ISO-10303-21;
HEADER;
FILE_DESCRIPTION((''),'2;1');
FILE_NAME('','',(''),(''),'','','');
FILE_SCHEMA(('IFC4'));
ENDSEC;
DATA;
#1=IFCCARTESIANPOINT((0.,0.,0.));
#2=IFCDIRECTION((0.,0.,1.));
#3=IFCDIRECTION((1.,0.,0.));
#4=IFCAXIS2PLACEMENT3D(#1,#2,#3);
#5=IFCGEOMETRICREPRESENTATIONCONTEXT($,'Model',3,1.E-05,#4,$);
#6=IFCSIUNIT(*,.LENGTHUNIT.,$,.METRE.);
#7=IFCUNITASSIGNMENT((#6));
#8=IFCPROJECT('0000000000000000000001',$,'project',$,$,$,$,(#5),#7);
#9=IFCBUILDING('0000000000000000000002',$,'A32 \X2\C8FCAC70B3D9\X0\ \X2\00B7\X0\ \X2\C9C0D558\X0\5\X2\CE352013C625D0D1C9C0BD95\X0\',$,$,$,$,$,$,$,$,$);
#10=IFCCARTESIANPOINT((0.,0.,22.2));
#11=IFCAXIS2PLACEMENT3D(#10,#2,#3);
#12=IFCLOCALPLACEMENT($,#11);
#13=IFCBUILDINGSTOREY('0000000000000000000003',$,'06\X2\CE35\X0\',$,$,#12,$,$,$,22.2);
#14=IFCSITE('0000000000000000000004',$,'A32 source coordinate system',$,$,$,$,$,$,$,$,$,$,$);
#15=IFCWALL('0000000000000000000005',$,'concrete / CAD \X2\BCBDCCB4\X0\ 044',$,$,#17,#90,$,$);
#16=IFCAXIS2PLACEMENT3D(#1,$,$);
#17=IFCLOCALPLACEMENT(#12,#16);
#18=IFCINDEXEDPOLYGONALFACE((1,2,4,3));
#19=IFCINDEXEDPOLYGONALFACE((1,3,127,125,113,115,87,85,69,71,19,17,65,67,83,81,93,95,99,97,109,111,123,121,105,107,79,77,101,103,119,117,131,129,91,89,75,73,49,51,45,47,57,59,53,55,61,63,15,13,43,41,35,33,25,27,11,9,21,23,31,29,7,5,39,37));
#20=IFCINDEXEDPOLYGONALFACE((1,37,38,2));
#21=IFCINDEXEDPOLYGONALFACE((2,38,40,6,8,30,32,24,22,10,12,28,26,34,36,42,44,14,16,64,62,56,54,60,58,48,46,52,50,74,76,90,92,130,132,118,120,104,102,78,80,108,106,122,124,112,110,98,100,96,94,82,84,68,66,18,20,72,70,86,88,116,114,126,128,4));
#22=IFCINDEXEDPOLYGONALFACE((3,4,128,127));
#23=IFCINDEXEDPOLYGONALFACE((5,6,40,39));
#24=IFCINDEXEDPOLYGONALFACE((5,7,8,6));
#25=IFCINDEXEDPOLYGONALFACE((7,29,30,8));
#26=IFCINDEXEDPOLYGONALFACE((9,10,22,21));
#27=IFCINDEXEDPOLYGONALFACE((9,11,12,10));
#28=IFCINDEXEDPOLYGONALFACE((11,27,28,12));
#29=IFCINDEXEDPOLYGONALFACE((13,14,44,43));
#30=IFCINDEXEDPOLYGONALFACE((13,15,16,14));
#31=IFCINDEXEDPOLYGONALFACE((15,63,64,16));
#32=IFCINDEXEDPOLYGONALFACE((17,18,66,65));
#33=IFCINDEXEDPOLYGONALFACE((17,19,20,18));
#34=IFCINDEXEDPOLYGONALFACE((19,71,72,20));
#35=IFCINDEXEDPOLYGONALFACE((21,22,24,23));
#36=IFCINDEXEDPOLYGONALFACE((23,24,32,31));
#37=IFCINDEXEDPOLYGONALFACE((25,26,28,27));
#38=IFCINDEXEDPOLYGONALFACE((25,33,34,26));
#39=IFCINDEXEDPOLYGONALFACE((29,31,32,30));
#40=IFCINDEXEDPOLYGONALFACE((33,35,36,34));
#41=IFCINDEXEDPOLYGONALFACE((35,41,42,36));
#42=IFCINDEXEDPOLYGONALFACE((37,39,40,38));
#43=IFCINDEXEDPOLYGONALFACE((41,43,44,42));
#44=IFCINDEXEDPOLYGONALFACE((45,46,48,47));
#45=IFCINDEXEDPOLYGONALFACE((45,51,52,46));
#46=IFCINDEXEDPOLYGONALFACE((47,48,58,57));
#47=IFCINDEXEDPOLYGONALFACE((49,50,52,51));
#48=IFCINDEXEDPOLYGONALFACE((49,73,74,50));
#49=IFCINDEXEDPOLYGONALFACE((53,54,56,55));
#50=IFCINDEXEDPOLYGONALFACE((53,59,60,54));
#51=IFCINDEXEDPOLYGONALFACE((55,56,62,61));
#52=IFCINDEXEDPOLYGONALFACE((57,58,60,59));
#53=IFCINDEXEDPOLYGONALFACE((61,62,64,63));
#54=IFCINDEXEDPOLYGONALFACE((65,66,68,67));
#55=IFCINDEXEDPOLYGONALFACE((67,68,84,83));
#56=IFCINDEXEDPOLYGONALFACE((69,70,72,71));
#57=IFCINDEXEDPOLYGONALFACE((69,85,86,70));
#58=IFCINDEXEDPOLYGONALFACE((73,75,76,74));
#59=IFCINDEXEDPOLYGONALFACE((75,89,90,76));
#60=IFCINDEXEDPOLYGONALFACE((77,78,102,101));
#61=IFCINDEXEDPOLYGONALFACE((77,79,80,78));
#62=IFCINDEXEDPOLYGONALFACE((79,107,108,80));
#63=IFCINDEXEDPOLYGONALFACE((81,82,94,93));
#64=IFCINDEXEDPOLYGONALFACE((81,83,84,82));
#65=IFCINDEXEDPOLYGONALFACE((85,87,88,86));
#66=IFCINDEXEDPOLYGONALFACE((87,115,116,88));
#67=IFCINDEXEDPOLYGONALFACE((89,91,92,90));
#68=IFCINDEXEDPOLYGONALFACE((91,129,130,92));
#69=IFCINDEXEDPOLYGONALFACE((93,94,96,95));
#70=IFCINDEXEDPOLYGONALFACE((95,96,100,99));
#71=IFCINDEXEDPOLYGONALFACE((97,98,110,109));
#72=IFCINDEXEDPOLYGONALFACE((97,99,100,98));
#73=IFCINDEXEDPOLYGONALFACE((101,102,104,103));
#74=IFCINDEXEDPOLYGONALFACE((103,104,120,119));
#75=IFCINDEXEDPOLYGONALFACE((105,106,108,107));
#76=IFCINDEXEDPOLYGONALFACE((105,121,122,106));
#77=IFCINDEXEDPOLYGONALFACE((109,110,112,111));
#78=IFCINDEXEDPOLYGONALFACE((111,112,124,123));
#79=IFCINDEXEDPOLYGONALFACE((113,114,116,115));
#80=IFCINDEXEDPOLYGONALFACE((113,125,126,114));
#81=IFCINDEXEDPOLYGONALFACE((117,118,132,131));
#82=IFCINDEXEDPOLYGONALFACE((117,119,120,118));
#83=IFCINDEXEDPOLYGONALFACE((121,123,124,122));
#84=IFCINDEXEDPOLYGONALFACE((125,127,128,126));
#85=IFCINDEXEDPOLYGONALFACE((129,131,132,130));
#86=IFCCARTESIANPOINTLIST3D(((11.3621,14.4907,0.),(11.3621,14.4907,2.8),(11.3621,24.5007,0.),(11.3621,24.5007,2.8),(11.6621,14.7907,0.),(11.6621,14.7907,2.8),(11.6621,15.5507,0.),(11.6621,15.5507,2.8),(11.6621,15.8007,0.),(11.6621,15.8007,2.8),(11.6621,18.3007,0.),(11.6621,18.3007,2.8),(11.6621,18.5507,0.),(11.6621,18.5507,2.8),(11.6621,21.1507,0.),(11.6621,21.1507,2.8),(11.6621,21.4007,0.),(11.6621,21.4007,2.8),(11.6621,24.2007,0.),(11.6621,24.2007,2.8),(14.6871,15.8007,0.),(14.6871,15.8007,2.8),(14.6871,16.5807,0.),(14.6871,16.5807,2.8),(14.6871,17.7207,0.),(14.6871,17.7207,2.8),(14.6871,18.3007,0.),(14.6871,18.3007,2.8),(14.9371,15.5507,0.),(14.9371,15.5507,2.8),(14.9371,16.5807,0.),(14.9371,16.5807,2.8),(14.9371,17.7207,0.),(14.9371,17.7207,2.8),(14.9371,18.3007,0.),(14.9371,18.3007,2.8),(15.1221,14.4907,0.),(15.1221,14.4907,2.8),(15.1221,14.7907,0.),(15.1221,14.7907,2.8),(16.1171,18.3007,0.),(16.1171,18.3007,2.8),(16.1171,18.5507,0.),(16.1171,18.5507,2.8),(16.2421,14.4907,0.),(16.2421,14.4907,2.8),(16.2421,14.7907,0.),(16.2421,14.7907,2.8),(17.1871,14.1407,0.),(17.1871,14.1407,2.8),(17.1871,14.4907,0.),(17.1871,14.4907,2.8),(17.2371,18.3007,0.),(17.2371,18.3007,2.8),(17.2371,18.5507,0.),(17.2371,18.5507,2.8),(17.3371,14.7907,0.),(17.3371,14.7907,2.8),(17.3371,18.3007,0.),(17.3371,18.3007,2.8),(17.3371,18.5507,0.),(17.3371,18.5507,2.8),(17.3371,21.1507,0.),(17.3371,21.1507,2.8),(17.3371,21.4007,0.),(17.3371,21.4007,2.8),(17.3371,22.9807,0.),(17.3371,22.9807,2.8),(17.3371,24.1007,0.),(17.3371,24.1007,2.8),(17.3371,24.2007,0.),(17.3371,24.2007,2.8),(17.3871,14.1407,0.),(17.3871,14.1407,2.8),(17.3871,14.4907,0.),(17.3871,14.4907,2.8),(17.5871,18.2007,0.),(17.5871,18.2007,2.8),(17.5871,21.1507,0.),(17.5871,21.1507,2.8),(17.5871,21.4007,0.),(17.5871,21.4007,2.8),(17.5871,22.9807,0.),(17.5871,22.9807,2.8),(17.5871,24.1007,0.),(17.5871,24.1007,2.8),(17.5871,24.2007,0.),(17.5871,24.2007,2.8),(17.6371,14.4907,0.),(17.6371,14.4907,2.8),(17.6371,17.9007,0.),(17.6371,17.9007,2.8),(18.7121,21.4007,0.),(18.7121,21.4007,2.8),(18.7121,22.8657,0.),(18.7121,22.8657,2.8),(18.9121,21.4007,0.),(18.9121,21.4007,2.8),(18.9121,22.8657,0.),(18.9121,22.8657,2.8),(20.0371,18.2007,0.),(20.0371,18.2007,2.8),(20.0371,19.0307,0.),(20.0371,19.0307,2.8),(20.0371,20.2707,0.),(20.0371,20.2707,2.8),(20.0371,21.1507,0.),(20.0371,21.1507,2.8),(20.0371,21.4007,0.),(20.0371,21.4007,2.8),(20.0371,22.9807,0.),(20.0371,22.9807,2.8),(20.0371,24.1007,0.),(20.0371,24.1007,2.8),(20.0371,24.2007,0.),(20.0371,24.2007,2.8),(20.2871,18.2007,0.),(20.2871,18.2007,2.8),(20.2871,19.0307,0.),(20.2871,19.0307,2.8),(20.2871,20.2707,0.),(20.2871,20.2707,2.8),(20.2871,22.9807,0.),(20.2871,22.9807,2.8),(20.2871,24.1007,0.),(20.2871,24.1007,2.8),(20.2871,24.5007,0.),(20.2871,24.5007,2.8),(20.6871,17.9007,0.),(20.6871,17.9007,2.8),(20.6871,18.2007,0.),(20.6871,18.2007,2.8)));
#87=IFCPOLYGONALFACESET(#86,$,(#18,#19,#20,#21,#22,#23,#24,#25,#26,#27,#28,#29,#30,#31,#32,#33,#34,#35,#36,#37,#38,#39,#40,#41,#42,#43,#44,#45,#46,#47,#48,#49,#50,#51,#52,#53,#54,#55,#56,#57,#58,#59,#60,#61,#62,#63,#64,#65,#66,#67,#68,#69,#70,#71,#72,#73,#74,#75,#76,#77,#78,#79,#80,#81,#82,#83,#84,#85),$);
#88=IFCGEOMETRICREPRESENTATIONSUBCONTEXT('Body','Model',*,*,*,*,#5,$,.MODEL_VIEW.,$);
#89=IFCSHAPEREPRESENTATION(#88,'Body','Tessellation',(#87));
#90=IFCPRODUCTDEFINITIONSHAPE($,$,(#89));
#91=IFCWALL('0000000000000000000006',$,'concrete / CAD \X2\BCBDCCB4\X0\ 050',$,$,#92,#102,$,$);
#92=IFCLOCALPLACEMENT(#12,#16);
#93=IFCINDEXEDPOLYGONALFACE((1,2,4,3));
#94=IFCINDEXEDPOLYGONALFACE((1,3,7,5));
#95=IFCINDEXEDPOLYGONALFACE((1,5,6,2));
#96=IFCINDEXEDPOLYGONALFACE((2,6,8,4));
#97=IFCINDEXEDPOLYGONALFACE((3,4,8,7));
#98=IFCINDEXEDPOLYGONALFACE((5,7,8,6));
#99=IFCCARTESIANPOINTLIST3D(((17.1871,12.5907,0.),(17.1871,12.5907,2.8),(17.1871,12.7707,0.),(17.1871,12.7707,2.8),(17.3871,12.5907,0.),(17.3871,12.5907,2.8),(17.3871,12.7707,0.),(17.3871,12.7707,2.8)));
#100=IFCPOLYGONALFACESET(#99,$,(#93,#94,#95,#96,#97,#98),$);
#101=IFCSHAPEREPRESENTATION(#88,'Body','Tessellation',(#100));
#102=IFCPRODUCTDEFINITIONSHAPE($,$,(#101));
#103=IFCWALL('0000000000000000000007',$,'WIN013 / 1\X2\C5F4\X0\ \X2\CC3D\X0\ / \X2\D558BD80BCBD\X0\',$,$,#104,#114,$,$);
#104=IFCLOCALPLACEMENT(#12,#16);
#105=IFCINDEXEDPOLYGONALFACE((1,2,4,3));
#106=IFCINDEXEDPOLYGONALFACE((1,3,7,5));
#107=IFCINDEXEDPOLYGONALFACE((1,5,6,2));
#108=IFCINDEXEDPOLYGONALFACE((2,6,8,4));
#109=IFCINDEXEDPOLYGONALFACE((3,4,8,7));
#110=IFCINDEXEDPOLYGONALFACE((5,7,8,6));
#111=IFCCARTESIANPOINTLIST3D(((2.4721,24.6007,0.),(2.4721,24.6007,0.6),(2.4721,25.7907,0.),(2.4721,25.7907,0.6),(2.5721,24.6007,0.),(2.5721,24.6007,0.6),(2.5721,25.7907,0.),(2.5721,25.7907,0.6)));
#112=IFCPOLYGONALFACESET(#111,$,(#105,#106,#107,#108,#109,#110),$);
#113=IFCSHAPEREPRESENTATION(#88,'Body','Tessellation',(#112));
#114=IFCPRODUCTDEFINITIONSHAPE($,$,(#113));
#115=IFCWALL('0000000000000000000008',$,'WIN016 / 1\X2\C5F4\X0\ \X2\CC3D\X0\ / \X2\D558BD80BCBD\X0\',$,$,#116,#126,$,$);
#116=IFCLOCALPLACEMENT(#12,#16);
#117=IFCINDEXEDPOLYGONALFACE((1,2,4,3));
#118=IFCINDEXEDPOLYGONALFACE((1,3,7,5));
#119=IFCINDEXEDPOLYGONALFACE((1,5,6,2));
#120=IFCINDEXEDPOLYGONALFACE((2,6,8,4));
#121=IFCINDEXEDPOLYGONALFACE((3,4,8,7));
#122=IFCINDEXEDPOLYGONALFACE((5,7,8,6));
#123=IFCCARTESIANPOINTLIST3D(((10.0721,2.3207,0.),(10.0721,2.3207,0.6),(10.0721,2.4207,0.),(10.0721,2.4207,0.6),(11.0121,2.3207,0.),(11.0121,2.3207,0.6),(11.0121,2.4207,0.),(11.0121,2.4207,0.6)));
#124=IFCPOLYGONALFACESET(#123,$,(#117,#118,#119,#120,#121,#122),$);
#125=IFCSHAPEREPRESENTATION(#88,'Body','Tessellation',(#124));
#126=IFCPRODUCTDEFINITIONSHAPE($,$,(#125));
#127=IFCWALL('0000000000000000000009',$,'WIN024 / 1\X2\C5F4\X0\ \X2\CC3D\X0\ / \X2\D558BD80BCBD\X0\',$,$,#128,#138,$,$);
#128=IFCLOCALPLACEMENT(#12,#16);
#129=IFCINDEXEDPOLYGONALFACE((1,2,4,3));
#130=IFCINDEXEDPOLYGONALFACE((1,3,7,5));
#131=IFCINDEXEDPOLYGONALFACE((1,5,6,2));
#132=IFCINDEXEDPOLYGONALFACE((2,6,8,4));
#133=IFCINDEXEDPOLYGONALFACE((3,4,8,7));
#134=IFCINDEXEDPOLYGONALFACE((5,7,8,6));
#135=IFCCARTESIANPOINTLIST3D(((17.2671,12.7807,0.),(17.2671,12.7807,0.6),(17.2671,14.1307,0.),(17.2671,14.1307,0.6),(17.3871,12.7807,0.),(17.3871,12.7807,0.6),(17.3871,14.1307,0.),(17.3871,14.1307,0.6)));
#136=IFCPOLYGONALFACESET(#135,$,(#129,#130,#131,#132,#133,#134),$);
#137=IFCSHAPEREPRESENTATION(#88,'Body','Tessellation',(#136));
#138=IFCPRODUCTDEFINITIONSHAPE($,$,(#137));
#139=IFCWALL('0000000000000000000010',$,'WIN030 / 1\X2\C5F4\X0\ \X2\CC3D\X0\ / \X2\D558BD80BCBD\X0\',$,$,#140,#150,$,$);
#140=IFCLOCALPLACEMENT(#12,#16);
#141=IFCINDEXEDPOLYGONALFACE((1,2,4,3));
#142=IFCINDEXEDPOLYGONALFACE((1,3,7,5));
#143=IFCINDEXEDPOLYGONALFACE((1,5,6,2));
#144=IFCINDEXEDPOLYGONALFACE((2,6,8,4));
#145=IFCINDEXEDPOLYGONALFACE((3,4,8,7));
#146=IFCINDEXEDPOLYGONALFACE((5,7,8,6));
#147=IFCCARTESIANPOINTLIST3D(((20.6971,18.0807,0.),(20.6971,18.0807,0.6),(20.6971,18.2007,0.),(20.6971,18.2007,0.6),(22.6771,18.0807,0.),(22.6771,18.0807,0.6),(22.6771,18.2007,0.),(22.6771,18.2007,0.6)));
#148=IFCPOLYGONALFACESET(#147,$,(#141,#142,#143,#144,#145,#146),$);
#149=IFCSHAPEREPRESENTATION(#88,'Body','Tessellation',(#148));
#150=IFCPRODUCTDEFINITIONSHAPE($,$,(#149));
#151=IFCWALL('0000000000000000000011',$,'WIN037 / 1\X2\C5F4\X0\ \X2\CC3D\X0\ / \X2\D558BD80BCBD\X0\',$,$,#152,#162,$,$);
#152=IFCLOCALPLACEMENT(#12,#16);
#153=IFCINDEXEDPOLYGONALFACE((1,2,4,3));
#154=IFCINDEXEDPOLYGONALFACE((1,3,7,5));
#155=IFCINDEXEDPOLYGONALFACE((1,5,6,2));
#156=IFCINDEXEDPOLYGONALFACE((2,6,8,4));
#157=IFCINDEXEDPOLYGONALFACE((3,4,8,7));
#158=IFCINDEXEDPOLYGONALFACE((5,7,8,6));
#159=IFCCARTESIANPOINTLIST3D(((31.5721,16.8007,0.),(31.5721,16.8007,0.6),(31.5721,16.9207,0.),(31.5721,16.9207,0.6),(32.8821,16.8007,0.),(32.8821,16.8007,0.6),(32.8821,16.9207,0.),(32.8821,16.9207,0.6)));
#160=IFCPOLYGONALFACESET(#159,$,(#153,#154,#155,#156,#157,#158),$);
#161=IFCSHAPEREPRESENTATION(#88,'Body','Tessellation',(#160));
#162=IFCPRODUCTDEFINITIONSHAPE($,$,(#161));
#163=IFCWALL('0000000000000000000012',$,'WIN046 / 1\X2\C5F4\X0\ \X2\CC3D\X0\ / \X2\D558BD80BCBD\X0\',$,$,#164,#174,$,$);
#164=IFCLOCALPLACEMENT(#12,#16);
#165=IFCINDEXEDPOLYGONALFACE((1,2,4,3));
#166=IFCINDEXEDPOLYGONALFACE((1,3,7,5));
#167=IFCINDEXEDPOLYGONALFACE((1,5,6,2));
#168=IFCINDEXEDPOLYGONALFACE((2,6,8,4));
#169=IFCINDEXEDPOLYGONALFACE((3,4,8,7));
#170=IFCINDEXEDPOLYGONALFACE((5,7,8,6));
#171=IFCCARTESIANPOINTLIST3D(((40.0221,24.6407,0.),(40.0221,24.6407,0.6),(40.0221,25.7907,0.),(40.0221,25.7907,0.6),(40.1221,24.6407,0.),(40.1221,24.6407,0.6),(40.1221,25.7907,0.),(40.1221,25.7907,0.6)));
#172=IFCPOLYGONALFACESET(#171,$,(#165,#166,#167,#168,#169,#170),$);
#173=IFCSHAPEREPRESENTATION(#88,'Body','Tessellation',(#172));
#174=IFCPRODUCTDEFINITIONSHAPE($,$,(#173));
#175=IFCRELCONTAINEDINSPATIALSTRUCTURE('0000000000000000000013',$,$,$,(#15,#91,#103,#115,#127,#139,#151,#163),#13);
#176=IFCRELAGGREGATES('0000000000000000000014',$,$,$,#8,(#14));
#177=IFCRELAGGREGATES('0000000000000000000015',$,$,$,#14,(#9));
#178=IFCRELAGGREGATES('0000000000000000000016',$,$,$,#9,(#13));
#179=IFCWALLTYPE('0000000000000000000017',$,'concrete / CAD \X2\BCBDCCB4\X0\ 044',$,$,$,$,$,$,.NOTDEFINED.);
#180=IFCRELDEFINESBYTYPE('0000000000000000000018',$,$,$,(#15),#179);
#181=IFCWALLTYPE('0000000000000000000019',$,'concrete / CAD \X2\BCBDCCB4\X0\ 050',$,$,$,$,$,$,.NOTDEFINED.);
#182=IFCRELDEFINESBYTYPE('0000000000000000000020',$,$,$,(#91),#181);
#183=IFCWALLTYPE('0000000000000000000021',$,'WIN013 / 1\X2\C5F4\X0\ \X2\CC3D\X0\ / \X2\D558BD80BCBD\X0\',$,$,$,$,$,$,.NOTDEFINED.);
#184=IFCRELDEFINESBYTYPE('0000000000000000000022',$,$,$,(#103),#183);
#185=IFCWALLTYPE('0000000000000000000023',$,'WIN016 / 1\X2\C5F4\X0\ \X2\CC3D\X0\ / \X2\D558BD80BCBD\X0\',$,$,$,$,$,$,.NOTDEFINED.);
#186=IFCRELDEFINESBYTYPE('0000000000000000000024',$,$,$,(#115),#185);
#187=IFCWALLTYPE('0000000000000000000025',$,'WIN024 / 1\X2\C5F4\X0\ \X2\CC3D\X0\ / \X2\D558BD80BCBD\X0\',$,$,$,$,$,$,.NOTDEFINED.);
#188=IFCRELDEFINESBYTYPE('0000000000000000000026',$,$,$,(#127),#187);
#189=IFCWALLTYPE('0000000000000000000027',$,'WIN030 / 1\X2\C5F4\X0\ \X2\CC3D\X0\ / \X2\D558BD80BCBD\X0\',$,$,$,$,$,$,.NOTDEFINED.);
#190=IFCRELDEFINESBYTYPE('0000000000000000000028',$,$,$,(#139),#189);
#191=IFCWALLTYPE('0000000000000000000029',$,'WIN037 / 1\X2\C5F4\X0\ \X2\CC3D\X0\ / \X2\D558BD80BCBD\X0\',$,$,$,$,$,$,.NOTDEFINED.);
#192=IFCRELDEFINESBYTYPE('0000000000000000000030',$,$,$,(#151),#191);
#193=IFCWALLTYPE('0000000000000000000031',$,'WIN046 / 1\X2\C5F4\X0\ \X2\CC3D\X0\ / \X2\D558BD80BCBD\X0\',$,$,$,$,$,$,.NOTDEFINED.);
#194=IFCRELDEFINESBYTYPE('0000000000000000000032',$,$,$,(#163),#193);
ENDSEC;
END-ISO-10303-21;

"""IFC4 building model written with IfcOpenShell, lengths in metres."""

from ifc_helpers import new_model, si_unit, frame, origin, origin_with_axes, place, context, subcontext, project, spatial, polyline, outline, extrude, source, transform, mapped, type_object, type_shapes, element, save


model = new_model("IFC4")

# Units and contexts
model_context = context("Model", 3, precision=1e-05, world=origin_with_axes())
body_context = subcontext(model_context, "Body", "Model", "MODEL_VIEW")
ifc_project = project(units=[si_unit("LENGTHUNIT", "METRE")], contexts=[model_context])

# Site, building, storey
site = spatial("IfcSite", under=ifc_project, Name="A32 source coordinate system")
building = spatial("IfcBuilding", under=site, Name="A32 주거동 · 지하5층–옥탑지붕")
storey_placement = place(None, frame((0.0, 0.0, 22.2), z_axis=(0.0, 0.0, 1.0), x_axis=(1.0, 0.0, 0.0)))
storey = spatial("IfcBuildingStorey", under=building, at=storey_placement, Name="06층", Elevation=22.2)

# Walls
wall_type_1 = type_object("IfcWallType", Name="concrete / CAD 벽체 044", PredefinedType="NOTDEFINED")
shared_shape_1 = source(origin(), body_context, "Body", "SweptSolid", [
    extrude(outline(polyline([(17.3371, 21.4007), (17.3371, 22.9807), (17.5871, 22.9807), (17.5871, 21.4007), (18.7121, 21.4007), (18.7121, 22.8657), (18.9121, 22.8657), (18.9121, 21.4007), (20.0371, 21.4007), (20.0371, 22.9807), (20.2871, 22.9807), (20.2871, 20.2707), (20.0371, 20.2707), (20.0371, 21.1507), (17.5871, 21.1507), (17.5871, 18.2007), (20.0371, 18.2007), (20.0371, 19.0307), (20.2871, 19.0307), (20.2871, 18.2007), (20.6871, 18.2007), (20.6871, 17.9007), (17.6371, 17.9007), (17.6371, 14.4907), (17.3871, 14.4907), (17.3871, 14.1407), (17.1871, 14.1407), (17.1871, 14.4907), (16.2421, 14.4907), (16.2421, 14.7907), (17.3371, 14.7907), (17.3371, 18.3007), (17.2371, 18.3007), (17.2371, 18.5507), (17.3371, 18.5507), (17.3371, 21.1507), (11.6621, 21.1507), (11.6621, 18.5507), (16.1171, 18.5507), (16.1171, 18.3007), (14.9371, 18.3007), (14.9371, 17.7207), (14.6871, 17.7207), (14.6871, 18.3007), (11.6621, 18.3007), (11.6621, 15.8007), (14.6871, 15.8007), (14.6871, 16.5807), (14.9371, 16.5807), (14.9371, 15.5507), (11.6621, 15.5507), (11.6621, 14.7907), (15.1221, 14.7907), (15.1221, 14.4907), (11.3621, 14.4907), (11.3621, 24.5007), (20.2871, 24.5007), (20.2871, 24.1007), (20.0371, 24.1007), (20.0371, 24.2007), (17.5871, 24.2007), (17.5871, 24.1007), (17.3371, 24.1007), (17.3371, 24.2007), (11.6621, 24.2007), (11.6621, 21.4007), (17.3371, 21.4007)])), origin(), (0.0, 0.0, 1.0), 2.8),
])
type_shapes(wall_type_1, [shared_shape_1])
wall_1_placement = place(storey_placement, origin_with_axes())
element("IfcWall", 1, at=wall_1_placement, inside=storey, type_object=wall_type_1, Name="concrete / CAD 벽체 044", context=body_context, shape_type="MappedRepresentation", body=[
    mapped(shared_shape_1, transform((0.0, 0.0, 0.0), scale=1.0)),
])
wall_type_2 = type_object("IfcWallType", Name="concrete / CAD 벽체 050", PredefinedType="NOTDEFINED")
shared_shape_2 = source(origin(), body_context, "Body", "SweptSolid", [
    extrude(outline(polyline([(17.3871, 12.5907), (17.1871, 12.5907), (17.1871, 12.7707), (17.3871, 12.7707), (17.3871, 12.5907)])), origin(), (0.0, 0.0, 1.0), 2.8),
])
type_shapes(wall_type_2, [shared_shape_2])
wall_2_placement = place(storey_placement, origin_with_axes())
element("IfcWall", 2, at=wall_2_placement, inside=storey, type_object=wall_type_2, Name="concrete / CAD 벽체 050", context=body_context, shape_type="MappedRepresentation", body=[
    mapped(shared_shape_2, transform((0.0, 0.0, 0.0), scale=1.0)),
])
wall_type_3 = type_object("IfcWallType", Name="WIN013 / 1열 창 / 하부벽", PredefinedType="NOTDEFINED")
shared_shape_3 = source(origin(), body_context, "Body", "SweptSolid", [
    extrude(outline(polyline([(2.5721, 25.7907), (2.5721, 24.6007), (2.4721, 24.6007), (2.4721, 25.7907), (2.5721, 25.7907)])), origin(), (0.0, 0.0, 1.0), 0.6),
])
type_shapes(wall_type_3, [shared_shape_3])
wall_3_placement = place(storey_placement, origin_with_axes())
element("IfcWall", 3, at=wall_3_placement, inside=storey, type_object=wall_type_3, Name="WIN013 / 1열 창 / 하부벽", context=body_context, shape_type="MappedRepresentation", body=[
    mapped(shared_shape_3, transform((0.0, 0.0, 0.0), scale=1.0)),
])
wall_type_4 = type_object("IfcWallType", Name="WIN016 / 1열 창 / 하부벽", PredefinedType="NOTDEFINED")
shared_shape_4 = source(origin(), body_context, "Body", "SweptSolid", [
    extrude(outline(polyline([(11.0121, 2.4207), (11.0121, 2.3207), (10.0721, 2.3207), (10.0721, 2.4207), (11.0121, 2.4207)])), origin(), (0.0, 0.0, 1.0), 0.6),
])
type_shapes(wall_type_4, [shared_shape_4])
wall_4_placement = place(storey_placement, origin_with_axes())
element("IfcWall", 4, at=wall_4_placement, inside=storey, type_object=wall_type_4, Name="WIN016 / 1열 창 / 하부벽", context=body_context, shape_type="MappedRepresentation", body=[
    mapped(shared_shape_4, transform((0.0, 0.0, 0.0), scale=1.0)),
])
wall_type_5 = type_object("IfcWallType", Name="WIN024 / 1열 창 / 하부벽", PredefinedType="NOTDEFINED")
shared_shape_5 = source(origin(), body_context, "Body", "SweptSolid", [
    extrude(outline(polyline([(17.3871, 14.1307), (17.3871, 12.7807), (17.2671, 12.7807), (17.2671, 14.1307), (17.3871, 14.1307)])), origin(), (0.0, 0.0, 1.0), 0.6),
])
type_shapes(wall_type_5, [shared_shape_5])
wall_5_placement = place(storey_placement, origin_with_axes())
element("IfcWall", 5, at=wall_5_placement, inside=storey, type_object=wall_type_5, Name="WIN024 / 1열 창 / 하부벽", context=body_context, shape_type="MappedRepresentation", body=[
    mapped(shared_shape_5, transform((0.0, 0.0, 0.0), scale=1.0)),
])
wall_type_6 = type_object("IfcWallType", Name="WIN030 / 1열 창 / 하부벽", PredefinedType="NOTDEFINED")
shared_shape_6 = source(origin(), body_context, "Body", "SweptSolid", [
    extrude(outline(polyline([(22.6771, 18.2007), (22.6771, 18.0807), (20.6971, 18.0807), (20.6971, 18.2007), (22.6771, 18.2007)])), origin(), (0.0, 0.0, 1.0), 0.6),
])
type_shapes(wall_type_6, [shared_shape_6])
wall_6_placement = place(storey_placement, origin_with_axes())
element("IfcWall", 6, at=wall_6_placement, inside=storey, type_object=wall_type_6, Name="WIN030 / 1열 창 / 하부벽", context=body_context, shape_type="MappedRepresentation", body=[
    mapped(shared_shape_6, transform((0.0, 0.0, 0.0), scale=1.0)),
])
wall_type_7 = type_object("IfcWallType", Name="WIN037 / 1열 창 / 하부벽", PredefinedType="NOTDEFINED")
shared_shape_7 = source(origin(), body_context, "Body", "SweptSolid", [
    extrude(outline(polyline([(32.8821, 16.9207), (32.8821, 16.8007), (31.5721, 16.8007), (31.5721, 16.9207), (32.8821, 16.9207)])), origin(), (0.0, 0.0, 1.0), 0.6),
])
type_shapes(wall_type_7, [shared_shape_7])
wall_7_placement = place(storey_placement, origin_with_axes())
element("IfcWall", 7, at=wall_7_placement, inside=storey, type_object=wall_type_7, Name="WIN037 / 1열 창 / 하부벽", context=body_context, shape_type="MappedRepresentation", body=[
    mapped(shared_shape_7, transform((0.0, 0.0, 0.0), scale=1.0)),
])
wall_type_8 = type_object("IfcWallType", Name="WIN046 / 1열 창 / 하부벽", PredefinedType="NOTDEFINED")
shared_shape_8 = source(origin(), body_context, "Body", "SweptSolid", [
    extrude(outline(polyline([(40.1221, 25.7907), (40.1221, 24.6407), (40.0221, 24.6407), (40.0221, 25.7907), (40.1221, 25.7907)])), origin(), (0.0, 0.0, 1.0), 0.6),
])
type_shapes(wall_type_8, [shared_shape_8])
wall_8_placement = place(storey_placement, origin_with_axes())
element("IfcWall", 8, at=wall_8_placement, inside=storey, type_object=wall_type_8, Name="WIN046 / 1열 창 / 하부벽", context=body_context, shape_type="MappedRepresentation", body=[
    mapped(shared_shape_8, transform((0.0, 0.0, 0.0), scale=1.0)),
])

save(model, "model.ifc")
